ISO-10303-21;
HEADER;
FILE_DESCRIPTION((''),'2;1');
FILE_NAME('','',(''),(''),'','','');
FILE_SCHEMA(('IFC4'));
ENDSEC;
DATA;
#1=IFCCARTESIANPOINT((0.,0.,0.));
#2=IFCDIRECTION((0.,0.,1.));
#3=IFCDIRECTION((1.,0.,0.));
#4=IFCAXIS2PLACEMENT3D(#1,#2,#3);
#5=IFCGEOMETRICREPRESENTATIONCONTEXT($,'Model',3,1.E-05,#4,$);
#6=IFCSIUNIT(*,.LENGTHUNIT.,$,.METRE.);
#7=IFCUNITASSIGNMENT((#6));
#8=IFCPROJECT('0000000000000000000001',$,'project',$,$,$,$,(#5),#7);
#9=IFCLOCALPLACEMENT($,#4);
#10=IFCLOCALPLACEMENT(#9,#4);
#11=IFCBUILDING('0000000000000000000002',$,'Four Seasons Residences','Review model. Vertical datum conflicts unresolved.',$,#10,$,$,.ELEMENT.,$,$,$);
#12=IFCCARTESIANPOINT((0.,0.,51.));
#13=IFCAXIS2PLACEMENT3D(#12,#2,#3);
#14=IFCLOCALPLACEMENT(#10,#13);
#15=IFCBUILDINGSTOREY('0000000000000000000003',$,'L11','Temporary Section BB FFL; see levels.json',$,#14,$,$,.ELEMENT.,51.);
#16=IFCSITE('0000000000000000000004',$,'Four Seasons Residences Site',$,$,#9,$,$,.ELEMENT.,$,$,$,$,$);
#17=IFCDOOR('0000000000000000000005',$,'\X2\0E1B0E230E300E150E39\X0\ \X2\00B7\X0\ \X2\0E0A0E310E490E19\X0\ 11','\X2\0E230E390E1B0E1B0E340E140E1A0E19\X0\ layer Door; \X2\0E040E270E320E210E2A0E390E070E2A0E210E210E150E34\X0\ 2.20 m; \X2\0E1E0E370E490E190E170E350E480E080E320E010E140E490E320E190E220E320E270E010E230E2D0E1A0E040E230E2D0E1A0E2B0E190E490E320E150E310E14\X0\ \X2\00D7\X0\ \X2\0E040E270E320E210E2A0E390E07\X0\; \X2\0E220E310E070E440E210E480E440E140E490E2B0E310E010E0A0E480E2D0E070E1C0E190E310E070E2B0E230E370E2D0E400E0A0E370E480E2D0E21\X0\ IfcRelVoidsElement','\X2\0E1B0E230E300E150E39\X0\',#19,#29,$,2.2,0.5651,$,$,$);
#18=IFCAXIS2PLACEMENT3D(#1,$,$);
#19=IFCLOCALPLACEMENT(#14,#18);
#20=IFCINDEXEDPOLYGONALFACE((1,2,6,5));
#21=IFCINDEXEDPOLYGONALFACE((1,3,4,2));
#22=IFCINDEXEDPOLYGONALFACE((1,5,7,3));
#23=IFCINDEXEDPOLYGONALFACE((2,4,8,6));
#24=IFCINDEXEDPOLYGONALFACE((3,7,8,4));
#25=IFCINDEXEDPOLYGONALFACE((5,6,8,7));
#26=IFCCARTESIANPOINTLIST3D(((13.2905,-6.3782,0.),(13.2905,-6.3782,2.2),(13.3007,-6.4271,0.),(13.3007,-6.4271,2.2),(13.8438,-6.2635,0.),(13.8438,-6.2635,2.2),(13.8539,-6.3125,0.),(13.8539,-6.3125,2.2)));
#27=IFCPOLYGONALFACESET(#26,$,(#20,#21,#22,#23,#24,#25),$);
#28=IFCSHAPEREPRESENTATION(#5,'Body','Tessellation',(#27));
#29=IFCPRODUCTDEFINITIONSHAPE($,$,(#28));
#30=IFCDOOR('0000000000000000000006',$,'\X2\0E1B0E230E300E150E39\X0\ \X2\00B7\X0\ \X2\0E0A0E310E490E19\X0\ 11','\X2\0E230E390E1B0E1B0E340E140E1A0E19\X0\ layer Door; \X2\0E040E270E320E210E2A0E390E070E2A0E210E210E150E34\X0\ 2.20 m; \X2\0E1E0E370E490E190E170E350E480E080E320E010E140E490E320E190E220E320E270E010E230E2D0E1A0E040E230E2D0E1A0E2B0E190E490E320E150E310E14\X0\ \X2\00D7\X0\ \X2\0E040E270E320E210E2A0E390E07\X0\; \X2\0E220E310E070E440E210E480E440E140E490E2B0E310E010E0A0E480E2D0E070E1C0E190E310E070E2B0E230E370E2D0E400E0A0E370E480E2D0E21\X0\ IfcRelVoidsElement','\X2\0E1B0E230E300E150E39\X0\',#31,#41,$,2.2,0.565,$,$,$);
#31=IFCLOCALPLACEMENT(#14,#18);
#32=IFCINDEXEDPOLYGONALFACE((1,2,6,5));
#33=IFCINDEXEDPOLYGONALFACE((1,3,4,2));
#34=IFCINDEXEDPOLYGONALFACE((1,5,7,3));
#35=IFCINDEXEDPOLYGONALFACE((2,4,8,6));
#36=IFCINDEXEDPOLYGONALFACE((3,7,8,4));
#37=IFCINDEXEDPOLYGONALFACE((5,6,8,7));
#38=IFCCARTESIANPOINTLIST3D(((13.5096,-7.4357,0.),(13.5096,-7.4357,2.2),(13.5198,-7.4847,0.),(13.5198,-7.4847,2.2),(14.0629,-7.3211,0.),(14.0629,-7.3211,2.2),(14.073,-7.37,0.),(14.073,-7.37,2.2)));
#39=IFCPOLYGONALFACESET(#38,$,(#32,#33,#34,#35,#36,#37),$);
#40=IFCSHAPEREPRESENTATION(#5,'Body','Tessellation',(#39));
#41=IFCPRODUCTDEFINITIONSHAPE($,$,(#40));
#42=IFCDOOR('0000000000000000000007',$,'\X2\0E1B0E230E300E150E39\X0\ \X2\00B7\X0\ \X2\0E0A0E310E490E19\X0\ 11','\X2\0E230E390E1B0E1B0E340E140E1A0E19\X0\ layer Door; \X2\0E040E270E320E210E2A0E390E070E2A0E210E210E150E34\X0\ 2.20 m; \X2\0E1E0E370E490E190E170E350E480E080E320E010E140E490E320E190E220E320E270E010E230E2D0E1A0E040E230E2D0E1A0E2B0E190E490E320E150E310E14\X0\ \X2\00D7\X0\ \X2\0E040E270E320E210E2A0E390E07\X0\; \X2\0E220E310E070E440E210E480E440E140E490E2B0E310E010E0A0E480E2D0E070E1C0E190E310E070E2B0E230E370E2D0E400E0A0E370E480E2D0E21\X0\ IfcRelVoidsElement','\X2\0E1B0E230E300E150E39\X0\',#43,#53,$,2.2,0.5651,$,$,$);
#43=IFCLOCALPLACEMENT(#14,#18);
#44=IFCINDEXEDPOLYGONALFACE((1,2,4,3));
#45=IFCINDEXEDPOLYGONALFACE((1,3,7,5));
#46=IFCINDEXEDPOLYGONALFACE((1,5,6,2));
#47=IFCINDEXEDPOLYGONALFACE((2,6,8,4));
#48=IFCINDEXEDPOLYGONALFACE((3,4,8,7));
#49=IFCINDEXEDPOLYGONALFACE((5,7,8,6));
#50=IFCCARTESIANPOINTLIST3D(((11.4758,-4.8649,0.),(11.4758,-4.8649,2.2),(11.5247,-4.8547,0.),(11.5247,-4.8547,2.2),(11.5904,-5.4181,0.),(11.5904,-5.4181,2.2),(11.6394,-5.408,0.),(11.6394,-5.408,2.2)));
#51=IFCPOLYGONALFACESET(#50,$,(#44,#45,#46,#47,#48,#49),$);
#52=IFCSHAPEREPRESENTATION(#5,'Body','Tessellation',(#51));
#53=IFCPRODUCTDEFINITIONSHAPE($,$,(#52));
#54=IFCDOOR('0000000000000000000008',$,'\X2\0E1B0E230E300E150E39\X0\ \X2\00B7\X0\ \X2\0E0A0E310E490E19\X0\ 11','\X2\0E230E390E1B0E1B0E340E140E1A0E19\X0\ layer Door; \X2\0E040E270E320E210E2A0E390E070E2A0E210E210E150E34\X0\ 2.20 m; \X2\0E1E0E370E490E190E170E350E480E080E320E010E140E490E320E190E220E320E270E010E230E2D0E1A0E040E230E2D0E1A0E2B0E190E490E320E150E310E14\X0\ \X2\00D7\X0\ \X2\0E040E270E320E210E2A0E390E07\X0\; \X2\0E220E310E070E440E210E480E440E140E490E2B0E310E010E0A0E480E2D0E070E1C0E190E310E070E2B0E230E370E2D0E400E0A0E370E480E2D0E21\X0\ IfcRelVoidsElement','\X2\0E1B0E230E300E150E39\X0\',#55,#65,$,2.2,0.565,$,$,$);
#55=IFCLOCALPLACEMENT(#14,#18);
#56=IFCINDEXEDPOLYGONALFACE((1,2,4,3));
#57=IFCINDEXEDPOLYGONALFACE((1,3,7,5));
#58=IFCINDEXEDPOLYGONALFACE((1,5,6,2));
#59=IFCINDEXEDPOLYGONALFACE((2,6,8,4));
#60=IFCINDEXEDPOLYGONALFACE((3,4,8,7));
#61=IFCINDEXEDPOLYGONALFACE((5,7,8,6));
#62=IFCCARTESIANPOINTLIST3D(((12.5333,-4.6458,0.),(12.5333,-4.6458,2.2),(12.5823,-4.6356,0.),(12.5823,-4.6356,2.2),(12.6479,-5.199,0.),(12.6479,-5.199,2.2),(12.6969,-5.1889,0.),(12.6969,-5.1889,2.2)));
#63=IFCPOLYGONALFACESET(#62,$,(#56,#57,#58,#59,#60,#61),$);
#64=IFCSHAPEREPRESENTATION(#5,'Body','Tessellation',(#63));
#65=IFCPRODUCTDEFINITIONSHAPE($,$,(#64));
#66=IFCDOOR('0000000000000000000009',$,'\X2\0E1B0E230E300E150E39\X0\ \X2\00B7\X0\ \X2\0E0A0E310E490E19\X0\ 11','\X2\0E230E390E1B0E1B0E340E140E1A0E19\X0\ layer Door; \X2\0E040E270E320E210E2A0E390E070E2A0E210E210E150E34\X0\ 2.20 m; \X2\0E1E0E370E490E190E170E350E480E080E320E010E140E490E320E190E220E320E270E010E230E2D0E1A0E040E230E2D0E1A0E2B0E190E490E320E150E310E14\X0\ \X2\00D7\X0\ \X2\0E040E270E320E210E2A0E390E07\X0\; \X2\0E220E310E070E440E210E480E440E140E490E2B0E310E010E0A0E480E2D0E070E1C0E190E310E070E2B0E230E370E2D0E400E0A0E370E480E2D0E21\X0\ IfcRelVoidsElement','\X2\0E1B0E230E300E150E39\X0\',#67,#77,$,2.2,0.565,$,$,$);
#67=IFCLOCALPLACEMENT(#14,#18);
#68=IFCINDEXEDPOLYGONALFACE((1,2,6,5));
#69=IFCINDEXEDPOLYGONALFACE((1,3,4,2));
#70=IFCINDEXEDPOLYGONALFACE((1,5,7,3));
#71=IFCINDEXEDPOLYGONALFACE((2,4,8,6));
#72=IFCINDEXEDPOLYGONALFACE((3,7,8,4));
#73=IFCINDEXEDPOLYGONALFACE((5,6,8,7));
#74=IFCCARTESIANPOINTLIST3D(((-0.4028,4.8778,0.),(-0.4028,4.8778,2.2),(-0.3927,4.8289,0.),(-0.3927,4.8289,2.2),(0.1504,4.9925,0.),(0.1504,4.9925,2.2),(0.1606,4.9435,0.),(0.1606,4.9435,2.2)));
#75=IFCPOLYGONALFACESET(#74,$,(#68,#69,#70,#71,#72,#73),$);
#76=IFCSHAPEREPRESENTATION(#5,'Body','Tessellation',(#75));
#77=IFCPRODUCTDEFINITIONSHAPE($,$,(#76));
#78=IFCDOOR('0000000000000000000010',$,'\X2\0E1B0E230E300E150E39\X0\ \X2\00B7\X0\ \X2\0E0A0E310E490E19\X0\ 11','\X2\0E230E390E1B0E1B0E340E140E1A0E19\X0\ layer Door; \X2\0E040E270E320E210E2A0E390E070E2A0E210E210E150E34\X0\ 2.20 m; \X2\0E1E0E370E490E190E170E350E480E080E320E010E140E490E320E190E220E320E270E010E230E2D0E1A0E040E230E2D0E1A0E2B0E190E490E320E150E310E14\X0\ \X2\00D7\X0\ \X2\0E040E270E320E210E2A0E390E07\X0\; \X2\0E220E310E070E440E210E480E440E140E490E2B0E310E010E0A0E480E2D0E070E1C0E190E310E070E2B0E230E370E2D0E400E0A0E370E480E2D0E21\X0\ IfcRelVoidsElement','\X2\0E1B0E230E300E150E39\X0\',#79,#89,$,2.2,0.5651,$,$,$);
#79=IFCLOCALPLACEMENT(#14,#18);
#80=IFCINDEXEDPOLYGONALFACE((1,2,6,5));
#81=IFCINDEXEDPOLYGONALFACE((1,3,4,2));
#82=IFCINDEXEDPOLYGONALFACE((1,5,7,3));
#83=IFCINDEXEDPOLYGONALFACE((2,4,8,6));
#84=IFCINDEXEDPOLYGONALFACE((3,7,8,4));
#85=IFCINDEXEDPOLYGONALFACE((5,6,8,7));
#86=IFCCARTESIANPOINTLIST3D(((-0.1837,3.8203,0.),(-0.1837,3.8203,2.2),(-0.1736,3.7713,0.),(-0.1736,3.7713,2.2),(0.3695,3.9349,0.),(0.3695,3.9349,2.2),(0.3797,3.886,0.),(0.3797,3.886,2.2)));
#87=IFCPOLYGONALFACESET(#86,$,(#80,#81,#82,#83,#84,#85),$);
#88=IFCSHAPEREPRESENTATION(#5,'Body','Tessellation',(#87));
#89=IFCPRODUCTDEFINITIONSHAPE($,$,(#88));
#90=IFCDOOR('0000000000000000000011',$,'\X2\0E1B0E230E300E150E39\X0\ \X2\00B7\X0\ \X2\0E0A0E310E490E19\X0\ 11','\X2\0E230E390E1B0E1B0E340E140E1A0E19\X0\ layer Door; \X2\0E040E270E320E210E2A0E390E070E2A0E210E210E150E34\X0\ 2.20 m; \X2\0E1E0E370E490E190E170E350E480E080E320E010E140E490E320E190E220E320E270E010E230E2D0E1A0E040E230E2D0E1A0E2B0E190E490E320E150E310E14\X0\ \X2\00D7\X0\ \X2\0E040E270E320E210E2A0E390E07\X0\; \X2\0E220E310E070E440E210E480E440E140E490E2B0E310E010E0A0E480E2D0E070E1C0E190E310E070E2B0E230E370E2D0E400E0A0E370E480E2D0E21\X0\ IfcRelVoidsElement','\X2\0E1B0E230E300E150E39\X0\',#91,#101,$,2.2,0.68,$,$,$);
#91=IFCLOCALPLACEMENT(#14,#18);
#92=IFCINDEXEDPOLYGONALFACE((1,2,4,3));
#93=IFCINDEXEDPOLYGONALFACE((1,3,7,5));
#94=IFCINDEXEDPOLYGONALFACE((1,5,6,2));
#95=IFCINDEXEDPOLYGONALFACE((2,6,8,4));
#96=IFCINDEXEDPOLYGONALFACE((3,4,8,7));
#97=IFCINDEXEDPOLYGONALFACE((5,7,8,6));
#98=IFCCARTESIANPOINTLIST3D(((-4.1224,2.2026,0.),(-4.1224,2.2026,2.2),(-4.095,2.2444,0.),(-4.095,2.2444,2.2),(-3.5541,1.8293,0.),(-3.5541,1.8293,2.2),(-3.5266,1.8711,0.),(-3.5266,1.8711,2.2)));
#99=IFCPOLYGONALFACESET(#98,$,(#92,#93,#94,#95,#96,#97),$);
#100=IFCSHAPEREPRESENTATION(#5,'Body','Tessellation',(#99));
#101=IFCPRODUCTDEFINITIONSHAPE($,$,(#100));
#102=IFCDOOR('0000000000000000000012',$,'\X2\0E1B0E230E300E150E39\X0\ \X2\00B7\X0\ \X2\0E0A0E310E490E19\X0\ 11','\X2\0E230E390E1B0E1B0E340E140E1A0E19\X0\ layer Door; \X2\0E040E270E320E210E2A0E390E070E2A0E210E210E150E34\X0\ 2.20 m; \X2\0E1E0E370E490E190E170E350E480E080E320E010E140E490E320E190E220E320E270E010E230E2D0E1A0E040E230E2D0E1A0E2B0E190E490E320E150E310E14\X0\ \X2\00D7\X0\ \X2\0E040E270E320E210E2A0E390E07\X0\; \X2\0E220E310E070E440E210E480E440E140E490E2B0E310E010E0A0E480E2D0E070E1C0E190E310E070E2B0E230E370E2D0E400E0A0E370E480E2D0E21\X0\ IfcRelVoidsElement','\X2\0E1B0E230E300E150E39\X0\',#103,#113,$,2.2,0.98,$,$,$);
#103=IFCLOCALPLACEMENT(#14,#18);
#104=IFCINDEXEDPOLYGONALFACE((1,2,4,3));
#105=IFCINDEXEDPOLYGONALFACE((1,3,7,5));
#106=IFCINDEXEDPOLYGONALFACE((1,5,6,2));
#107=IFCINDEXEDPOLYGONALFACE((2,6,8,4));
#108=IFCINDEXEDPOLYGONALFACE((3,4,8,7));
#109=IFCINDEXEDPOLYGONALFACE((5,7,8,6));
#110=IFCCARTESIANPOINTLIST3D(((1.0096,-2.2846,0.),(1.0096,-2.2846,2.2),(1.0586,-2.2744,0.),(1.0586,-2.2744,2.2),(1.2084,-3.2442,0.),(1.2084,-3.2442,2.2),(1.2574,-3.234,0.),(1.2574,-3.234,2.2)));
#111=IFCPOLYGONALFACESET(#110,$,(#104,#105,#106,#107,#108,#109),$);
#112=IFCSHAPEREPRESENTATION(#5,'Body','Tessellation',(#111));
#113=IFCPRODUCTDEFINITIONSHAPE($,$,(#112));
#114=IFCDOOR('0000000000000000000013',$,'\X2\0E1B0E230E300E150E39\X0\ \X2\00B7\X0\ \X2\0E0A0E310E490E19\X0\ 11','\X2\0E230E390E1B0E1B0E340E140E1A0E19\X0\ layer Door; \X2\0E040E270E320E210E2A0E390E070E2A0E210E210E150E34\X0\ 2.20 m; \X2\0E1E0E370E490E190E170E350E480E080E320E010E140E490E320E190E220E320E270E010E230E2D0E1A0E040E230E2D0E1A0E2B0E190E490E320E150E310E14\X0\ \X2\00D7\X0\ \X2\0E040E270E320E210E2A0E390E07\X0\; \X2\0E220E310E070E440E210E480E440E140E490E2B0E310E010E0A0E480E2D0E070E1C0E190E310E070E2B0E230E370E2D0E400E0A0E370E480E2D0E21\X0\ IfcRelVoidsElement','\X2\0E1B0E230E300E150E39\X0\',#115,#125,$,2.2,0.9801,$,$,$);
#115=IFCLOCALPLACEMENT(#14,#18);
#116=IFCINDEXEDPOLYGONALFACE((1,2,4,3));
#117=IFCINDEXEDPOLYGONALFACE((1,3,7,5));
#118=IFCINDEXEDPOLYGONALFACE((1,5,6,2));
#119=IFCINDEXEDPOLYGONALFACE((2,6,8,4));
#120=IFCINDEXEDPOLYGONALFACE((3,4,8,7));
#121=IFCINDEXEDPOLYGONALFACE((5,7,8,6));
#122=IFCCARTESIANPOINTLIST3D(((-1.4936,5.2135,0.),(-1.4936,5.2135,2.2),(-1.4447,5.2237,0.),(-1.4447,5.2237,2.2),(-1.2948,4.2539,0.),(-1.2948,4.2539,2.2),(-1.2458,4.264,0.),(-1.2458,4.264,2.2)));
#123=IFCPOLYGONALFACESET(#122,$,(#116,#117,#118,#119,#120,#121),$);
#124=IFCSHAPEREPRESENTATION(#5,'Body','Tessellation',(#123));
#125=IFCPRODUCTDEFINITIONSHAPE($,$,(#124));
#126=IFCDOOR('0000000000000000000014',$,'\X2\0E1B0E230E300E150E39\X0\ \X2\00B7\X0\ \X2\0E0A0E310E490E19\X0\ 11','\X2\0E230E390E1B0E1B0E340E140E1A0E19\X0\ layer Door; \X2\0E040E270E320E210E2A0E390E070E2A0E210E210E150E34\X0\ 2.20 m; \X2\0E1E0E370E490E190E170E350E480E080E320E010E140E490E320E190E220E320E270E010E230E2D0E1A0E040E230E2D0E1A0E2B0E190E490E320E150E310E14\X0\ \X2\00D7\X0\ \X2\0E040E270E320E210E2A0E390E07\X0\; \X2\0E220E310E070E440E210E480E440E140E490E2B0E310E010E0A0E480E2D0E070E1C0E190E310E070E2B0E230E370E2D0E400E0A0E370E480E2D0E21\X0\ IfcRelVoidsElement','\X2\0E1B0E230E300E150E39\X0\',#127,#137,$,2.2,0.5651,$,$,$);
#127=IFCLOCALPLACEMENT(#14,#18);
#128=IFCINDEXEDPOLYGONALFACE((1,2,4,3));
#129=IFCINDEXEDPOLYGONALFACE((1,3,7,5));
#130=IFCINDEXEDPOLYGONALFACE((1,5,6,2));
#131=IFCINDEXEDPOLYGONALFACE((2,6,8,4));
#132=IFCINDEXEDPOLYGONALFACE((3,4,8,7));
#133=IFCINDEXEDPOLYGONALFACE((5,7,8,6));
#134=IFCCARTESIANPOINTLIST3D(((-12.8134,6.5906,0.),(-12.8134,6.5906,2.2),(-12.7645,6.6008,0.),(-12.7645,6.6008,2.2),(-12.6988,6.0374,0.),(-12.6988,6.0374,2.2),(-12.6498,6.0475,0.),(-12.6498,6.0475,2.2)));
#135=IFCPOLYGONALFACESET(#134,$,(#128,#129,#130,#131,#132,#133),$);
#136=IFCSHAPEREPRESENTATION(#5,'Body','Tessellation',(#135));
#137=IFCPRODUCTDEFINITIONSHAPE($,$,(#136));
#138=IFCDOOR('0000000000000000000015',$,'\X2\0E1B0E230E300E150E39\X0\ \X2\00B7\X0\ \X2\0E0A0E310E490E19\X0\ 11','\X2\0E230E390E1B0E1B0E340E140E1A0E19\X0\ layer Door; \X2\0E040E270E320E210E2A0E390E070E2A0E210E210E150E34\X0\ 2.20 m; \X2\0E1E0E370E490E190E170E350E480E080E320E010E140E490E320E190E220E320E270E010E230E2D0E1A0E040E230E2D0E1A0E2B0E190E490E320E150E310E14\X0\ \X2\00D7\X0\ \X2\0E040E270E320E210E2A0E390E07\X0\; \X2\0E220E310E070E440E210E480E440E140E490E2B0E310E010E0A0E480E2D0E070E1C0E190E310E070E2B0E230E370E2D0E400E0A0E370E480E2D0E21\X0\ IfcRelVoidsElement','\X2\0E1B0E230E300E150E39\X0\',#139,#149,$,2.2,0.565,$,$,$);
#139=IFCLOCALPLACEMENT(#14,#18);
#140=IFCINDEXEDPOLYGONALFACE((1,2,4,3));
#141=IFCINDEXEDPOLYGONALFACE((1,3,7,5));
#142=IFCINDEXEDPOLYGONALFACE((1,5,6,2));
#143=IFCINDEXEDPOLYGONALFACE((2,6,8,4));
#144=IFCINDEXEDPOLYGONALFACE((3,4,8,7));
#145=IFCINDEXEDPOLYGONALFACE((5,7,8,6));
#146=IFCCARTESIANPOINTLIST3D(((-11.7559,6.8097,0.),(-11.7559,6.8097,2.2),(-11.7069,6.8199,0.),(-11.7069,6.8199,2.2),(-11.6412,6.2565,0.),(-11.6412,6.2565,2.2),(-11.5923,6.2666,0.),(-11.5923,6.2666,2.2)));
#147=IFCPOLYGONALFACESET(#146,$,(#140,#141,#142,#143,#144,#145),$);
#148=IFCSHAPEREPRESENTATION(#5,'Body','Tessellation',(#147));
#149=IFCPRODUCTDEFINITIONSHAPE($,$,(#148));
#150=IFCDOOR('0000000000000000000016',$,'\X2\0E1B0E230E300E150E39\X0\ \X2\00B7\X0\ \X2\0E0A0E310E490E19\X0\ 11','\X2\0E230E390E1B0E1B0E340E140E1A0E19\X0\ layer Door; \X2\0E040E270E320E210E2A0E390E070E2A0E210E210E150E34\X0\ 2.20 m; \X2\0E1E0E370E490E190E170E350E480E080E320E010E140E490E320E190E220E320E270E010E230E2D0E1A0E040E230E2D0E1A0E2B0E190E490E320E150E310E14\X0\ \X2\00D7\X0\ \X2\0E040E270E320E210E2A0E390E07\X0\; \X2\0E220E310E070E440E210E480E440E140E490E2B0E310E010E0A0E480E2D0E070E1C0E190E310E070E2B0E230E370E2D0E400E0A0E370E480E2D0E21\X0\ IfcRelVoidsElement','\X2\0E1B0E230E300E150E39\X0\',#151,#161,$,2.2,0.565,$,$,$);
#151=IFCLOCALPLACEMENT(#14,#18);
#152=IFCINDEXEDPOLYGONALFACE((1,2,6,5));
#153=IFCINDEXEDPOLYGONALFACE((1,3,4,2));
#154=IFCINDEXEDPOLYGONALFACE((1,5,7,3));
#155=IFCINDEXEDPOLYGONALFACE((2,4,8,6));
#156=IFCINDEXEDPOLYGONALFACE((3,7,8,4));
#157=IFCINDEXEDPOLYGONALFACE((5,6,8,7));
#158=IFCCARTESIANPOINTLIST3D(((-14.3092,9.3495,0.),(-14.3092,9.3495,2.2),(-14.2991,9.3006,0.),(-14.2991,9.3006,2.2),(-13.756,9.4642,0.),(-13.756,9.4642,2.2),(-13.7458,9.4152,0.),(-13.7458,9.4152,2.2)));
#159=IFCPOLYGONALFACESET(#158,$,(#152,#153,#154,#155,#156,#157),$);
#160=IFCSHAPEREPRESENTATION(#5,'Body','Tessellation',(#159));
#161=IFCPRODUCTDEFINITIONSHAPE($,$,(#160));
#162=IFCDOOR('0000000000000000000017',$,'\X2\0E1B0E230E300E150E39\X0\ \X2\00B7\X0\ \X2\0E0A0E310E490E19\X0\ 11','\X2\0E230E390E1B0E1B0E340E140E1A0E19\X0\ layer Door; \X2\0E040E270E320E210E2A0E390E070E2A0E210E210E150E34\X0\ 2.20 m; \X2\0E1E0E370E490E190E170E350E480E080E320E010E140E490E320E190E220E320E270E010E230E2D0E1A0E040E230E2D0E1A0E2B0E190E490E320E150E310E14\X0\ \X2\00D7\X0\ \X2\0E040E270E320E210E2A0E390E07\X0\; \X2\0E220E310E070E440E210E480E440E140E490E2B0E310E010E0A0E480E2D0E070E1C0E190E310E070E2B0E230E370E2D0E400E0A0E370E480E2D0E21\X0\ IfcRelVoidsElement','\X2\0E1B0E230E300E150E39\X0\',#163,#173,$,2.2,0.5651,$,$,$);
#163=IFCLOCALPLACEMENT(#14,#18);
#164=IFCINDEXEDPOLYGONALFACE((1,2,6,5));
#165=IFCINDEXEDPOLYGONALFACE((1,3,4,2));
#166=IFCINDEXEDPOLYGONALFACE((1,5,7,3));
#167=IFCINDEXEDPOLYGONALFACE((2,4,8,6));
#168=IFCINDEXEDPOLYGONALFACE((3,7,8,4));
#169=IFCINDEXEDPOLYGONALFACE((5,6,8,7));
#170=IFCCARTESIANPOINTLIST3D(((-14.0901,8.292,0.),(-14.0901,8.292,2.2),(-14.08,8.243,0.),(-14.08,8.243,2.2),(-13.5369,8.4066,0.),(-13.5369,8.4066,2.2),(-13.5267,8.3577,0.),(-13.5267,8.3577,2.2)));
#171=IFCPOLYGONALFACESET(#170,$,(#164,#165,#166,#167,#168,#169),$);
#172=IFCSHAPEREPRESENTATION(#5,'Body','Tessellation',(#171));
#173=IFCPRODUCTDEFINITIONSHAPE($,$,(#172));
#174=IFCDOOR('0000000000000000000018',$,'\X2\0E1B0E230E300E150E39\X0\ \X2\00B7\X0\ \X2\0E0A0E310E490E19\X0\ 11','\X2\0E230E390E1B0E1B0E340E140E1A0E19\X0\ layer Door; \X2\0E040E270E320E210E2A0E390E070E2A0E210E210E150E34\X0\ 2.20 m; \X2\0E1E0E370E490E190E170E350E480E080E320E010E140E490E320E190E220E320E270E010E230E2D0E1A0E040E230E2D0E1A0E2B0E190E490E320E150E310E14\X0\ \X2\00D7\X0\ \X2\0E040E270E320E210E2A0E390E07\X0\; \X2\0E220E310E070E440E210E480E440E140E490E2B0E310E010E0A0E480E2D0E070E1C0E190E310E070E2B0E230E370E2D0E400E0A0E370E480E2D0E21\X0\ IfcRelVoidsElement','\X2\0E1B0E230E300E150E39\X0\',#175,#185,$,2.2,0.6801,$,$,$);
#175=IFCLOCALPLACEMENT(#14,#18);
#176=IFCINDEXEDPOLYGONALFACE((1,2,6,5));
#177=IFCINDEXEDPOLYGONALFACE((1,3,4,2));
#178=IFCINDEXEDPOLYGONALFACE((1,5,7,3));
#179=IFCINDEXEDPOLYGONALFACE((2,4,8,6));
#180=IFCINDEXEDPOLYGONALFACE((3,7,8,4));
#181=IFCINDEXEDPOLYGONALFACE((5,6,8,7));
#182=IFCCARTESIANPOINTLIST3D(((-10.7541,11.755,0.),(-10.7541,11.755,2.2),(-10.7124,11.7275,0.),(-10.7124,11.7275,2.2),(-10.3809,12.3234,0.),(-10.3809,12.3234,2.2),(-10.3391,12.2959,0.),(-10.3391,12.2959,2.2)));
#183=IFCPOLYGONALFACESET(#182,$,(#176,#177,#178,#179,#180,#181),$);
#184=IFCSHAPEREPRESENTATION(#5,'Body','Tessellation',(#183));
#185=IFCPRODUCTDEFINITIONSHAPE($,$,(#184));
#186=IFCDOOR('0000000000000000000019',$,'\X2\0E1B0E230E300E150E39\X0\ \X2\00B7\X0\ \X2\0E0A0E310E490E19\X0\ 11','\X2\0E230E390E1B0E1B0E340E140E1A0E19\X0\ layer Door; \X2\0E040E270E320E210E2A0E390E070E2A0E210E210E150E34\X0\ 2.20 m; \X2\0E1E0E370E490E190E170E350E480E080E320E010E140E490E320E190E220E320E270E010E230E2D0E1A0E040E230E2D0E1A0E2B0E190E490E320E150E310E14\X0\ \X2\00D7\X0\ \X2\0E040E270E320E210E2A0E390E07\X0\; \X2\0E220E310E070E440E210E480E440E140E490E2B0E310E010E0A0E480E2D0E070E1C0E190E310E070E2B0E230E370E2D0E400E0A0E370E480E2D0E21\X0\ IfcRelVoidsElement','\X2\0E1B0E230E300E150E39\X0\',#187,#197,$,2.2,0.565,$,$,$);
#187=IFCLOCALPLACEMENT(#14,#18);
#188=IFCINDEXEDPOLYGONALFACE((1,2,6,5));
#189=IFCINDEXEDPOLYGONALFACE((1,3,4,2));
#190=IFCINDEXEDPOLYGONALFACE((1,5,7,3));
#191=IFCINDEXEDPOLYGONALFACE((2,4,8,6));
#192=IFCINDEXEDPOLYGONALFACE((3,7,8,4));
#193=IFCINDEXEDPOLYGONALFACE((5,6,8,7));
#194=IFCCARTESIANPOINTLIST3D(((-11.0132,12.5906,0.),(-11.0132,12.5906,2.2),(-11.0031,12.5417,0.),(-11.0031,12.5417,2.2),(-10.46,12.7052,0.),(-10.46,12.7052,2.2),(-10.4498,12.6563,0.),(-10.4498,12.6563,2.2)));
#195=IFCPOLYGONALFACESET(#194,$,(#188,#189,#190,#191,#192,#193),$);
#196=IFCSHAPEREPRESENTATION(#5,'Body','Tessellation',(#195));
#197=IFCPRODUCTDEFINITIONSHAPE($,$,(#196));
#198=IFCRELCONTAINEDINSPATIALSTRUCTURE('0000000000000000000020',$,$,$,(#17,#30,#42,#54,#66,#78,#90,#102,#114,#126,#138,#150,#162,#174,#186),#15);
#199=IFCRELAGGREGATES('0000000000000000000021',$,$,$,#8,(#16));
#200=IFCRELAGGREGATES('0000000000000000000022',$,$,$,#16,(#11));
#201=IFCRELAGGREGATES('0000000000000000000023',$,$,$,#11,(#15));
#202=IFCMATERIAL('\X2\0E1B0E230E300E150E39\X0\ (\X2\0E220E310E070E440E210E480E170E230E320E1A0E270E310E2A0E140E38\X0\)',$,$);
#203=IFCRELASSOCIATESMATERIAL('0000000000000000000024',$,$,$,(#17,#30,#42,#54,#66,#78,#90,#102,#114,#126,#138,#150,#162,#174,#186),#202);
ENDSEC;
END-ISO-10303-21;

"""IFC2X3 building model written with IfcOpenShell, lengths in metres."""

from ifc_helpers import new_model, si_unit, frame, origin_with_axes, place, context, project, spatial, polyline, outline, extrude, material, element, save


model = new_model("IFC2X3")

# Units and contexts
model_context = context("Model", 3, precision=1e-05, world=origin_with_axes())
ifc_project = project(units=[si_unit("LENGTHUNIT", "METRE")], contexts=[model_context])

# Site, building, storey
site_placement = place(None, origin_with_axes())
site = spatial("IfcSite", under=ifc_project, at=site_placement, Name="Four Seasons Residences Site", CompositionType="ELEMENT")
building_placement = place(site_placement, origin_with_axes())
building = spatial("IfcBuilding", under=site, at=building_placement, Name="Four Seasons Residences", Description="Review model. Vertical datum conflicts unresolved.", CompositionType="ELEMENT")
storey_placement = place(building_placement, frame((0.0, 0.0, 51.0), z_axis=(0.0, 0.0, 1.0), x_axis=(1.0, 0.0, 0.0)))
storey = spatial("IfcBuildingStorey", under=building, at=storey_placement, Name="L11", Description="Temporary Section BB FFL; see levels.json", CompositionType="ELEMENT", Elevation=51.0)

# Doors
ifc_material_1 = material(Name="ประตู (ยังไม่ทราบวัสดุ)")
door_1_placement = place(storey_placement, origin_with_axes())
element("IfcDoor", 1, at=door_1_placement, inside=storey, material=ifc_material_1, Name="ประตู · ชั้น 11", Description="รูปปิดบน layer Door; ความสูงสมมติ 2.20 m; พื้นที่จากด้านยาวกรอบครอบหน้าตัด × ความสูง; ยังไม่ได้หักช่องผนังหรือเชื่อม IfcRelVoidsElement", ObjectType="ประตู", OverallHeight=2.2, OverallWidth=0.5651, context=model_context, shape_type="SweptSolid", body=[
    extrude(outline(polyline([(13.2905, -6.3782), (13.8438, -6.2635), (13.8539, -6.3125), (13.3007, -6.4271), (13.2905, -6.3782)])), origin_with_axes(), (0.0, 0.0, 1.0), 2.2),
])
door_2_placement = place(storey_placement, origin_with_axes())
element("IfcDoor", 2, at=door_2_placement, inside=storey, material=ifc_material_1, Name="ประตู · ชั้น 11", Description="รูปปิดบน layer Door; ความสูงสมมติ 2.20 m; พื้นที่จากด้านยาวกรอบครอบหน้าตัด × ความสูง; ยังไม่ได้หักช่องผนังหรือเชื่อม IfcRelVoidsElement", ObjectType="ประตู", OverallHeight=2.2, OverallWidth=0.565, context=model_context, shape_type="SweptSolid", body=[
    extrude(outline(polyline([(13.5198, -7.4847), (14.073, -7.37), (14.0629, -7.3211), (13.5096, -7.4357), (13.5198, -7.4847)])), origin_with_axes(), (0.0, 0.0, 1.0), 2.2),
])
door_3_placement = place(storey_placement, origin_with_axes())
element("IfcDoor", 3, at=door_3_placement, inside=storey, material=ifc_material_1, Name="ประตู · ชั้น 11", Description="รูปปิดบน layer Door; ความสูงสมมติ 2.20 m; พื้นที่จากด้านยาวกรอบครอบหน้าตัด × ความสูง; ยังไม่ได้หักช่องผนังหรือเชื่อม IfcRelVoidsElement", ObjectType="ประตู", OverallHeight=2.2, OverallWidth=0.5651, context=model_context, shape_type="SweptSolid", body=[
    extrude(outline(polyline([(11.4758, -4.8649), (11.5904, -5.4181), (11.6394, -5.408), (11.5247, -4.8547), (11.4758, -4.8649)])), origin_with_axes(), (0.0, 0.0, 1.0), 2.2),
])
door_4_placement = place(storey_placement, origin_with_axes())
element("IfcDoor", 4, at=door_4_placement, inside=storey, material=ifc_material_1, Name="ประตู · ชั้น 11", Description="รูปปิดบน layer Door; ความสูงสมมติ 2.20 m; พื้นที่จากด้านยาวกรอบครอบหน้าตัด × ความสูง; ยังไม่ได้หักช่องผนังหรือเชื่อม IfcRelVoidsElement", ObjectType="ประตู", OverallHeight=2.2, OverallWidth=0.565, context=model_context, shape_type="SweptSolid", body=[
    extrude(outline(polyline([(12.5823, -4.6356), (12.6969, -5.1889), (12.6479, -5.199), (12.5333, -4.6458), (12.5823, -4.6356)])), origin_with_axes(), (0.0, 0.0, 1.0), 2.2),
])
door_5_placement = place(storey_placement, origin_with_axes())
element("IfcDoor", 5, at=door_5_placement, inside=storey, material=ifc_material_1, Name="ประตู · ชั้น 11", Description="รูปปิดบน layer Door; ความสูงสมมติ 2.20 m; พื้นที่จากด้านยาวกรอบครอบหน้าตัด × ความสูง; ยังไม่ได้หักช่องผนังหรือเชื่อม IfcRelVoidsElement", ObjectType="ประตู", OverallHeight=2.2, OverallWidth=0.565, context=model_context, shape_type="SweptSolid", body=[
    extrude(outline(polyline([(-0.4028, 4.8778), (0.1504, 4.9925), (0.1606, 4.9435), (-0.3927, 4.8289), (-0.4028, 4.8778)])), origin_with_axes(), (0.0, 0.0, 1.0), 2.2),
])
door_6_placement = place(storey_placement, origin_with_axes())
element("IfcDoor", 6, at=door_6_placement, inside=storey, material=ifc_material_1, Name="ประตู · ชั้น 11", Description="รูปปิดบน layer Door; ความสูงสมมติ 2.20 m; พื้นที่จากด้านยาวกรอบครอบหน้าตัด × ความสูง; ยังไม่ได้หักช่องผนังหรือเชื่อม IfcRelVoidsElement", ObjectType="ประตู", OverallHeight=2.2, OverallWidth=0.5651, context=model_context, shape_type="SweptSolid", body=[
    extrude(outline(polyline([(-0.1736, 3.7713), (0.3797, 3.886), (0.3695, 3.9349), (-0.1837, 3.8203), (-0.1736, 3.7713)])), origin_with_axes(), (0.0, 0.0, 1.0), 2.2),
])
door_7_placement = place(storey_placement, origin_with_axes())
element("IfcDoor", 7, at=door_7_placement, inside=storey, material=ifc_material_1, Name="ประตู · ชั้น 11", Description="รูปปิดบน layer Door; ความสูงสมมติ 2.20 m; พื้นที่จากด้านยาวกรอบครอบหน้าตัด × ความสูง; ยังไม่ได้หักช่องผนังหรือเชื่อม IfcRelVoidsElement", ObjectType="ประตู", OverallHeight=2.2, OverallWidth=0.68, context=model_context, shape_type="SweptSolid", body=[
    extrude(outline(polyline([(-3.5541, 1.8293), (-4.1224, 2.2026), (-4.095, 2.2444), (-3.5266, 1.8711), (-3.5541, 1.8293)])), origin_with_axes(), (0.0, 0.0, 1.0), 2.2),
])
door_8_placement = place(storey_placement, origin_with_axes())
element("IfcDoor", 8, at=door_8_placement, inside=storey, material=ifc_material_1, Name="ประตู · ชั้น 11", Description="รูปปิดบน layer Door; ความสูงสมมติ 2.20 m; พื้นที่จากด้านยาวกรอบครอบหน้าตัด × ความสูง; ยังไม่ได้หักช่องผนังหรือเชื่อม IfcRelVoidsElement", ObjectType="ประตู", OverallHeight=2.2, OverallWidth=0.98, context=model_context, shape_type="SweptSolid", body=[
    extrude(outline(polyline([(1.2574, -3.234), (1.2084, -3.2442), (1.0096, -2.2846), (1.0586, -2.2744), (1.2574, -3.234)])), origin_with_axes(), (0.0, 0.0, 1.0), 2.2),
])
door_9_placement = place(storey_placement, origin_with_axes())
element("IfcDoor", 9, at=door_9_placement, inside=storey, material=ifc_material_1, Name="ประตู · ชั้น 11", Description="รูปปิดบน layer Door; ความสูงสมมติ 2.20 m; พื้นที่จากด้านยาวกรอบครอบหน้าตัด × ความสูง; ยังไม่ได้หักช่องผนังหรือเชื่อม IfcRelVoidsElement", ObjectType="ประตู", OverallHeight=2.2, OverallWidth=0.9801, context=model_context, shape_type="SweptSolid", body=[
    extrude(outline(polyline([(-1.4936, 5.2135), (-1.4447, 5.2237), (-1.2458, 4.264), (-1.2948, 4.2539), (-1.4936, 5.2135)])), origin_with_axes(), (0.0, 0.0, 1.0), 2.2),
])
door_10_placement = place(storey_placement, origin_with_axes())
element("IfcDoor", 10, at=door_10_placement, inside=storey, material=ifc_material_1, Name="ประตู · ชั้น 11", Description="รูปปิดบน layer Door; ความสูงสมมติ 2.20 m; พื้นที่จากด้านยาวกรอบครอบหน้าตัด × ความสูง; ยังไม่ได้หักช่องผนังหรือเชื่อม IfcRelVoidsElement", ObjectType="ประตู", OverallHeight=2.2, OverallWidth=0.5651, context=model_context, shape_type="SweptSolid", body=[
    extrude(outline(polyline([(-12.6988, 6.0374), (-12.8134, 6.5906), (-12.7645, 6.6008), (-12.6498, 6.0475), (-12.6988, 6.0374)])), origin_with_axes(), (0.0, 0.0, 1.0), 2.2),
])
door_11_placement = place(storey_placement, origin_with_axes())
element("IfcDoor", 11, at=door_11_placement, inside=storey, material=ifc_material_1, Name="ประตู · ชั้น 11", Description="รูปปิดบน layer Door; ความสูงสมมติ 2.20 m; พื้นที่จากด้านยาวกรอบครอบหน้าตัด × ความสูง; ยังไม่ได้หักช่องผนังหรือเชื่อม IfcRelVoidsElement", ObjectType="ประตู", OverallHeight=2.2, OverallWidth=0.565, context=model_context, shape_type="SweptSolid", body=[
    extrude(outline(polyline([(-11.5923, 6.2666), (-11.7069, 6.8199), (-11.7559, 6.8097), (-11.6412, 6.2565), (-11.5923, 6.2666)])), origin_with_axes(), (0.0, 0.0, 1.0), 2.2),
])
door_12_placement = place(storey_placement, origin_with_axes())
element("IfcDoor", 12, at=door_12_placement, inside=storey, material=ifc_material_1, Name="ประตู · ชั้น 11", Description="รูปปิดบน layer Door; ความสูงสมมติ 2.20 m; พื้นที่จากด้านยาวกรอบครอบหน้าตัด × ความสูง; ยังไม่ได้หักช่องผนังหรือเชื่อม IfcRelVoidsElement", ObjectType="ประตู", OverallHeight=2.2, OverallWidth=0.565, context=model_context, shape_type="SweptSolid", body=[
    extrude(outline(polyline([(-13.756, 9.4642), (-14.3092, 9.3495), (-14.2991, 9.3006), (-13.7458, 9.4152), (-13.756, 9.4642)])), origin_with_axes(), (0.0, 0.0, 1.0), 2.2),
])
door_13_placement = place(storey_placement, origin_with_axes())
element("IfcDoor", 13, at=door_13_placement, inside=storey, material=ifc_material_1, Name="ประตู · ชั้น 11", Description="รูปปิดบน layer Door; ความสูงสมมติ 2.20 m; พื้นที่จากด้านยาวกรอบครอบหน้าตัด × ความสูง; ยังไม่ได้หักช่องผนังหรือเชื่อม IfcRelVoidsElement", ObjectType="ประตู", OverallHeight=2.2, OverallWidth=0.5651, context=model_context, shape_type="SweptSolid", body=[
    extrude(outline(polyline([(-13.5267, 8.3577), (-14.08, 8.243), (-14.0901, 8.292), (-13.5369, 8.4066), (-13.5267, 8.3577)])), origin_with_axes(), (0.0, 0.0, 1.0), 2.2),
])
door_14_placement = place(storey_placement, origin_with_axes())
element("IfcDoor", 14, at=door_14_placement, inside=storey, material=ifc_material_1, Name="ประตู · ชั้น 11", Description="รูปปิดบน layer Door; ความสูงสมมติ 2.20 m; พื้นที่จากด้านยาวกรอบครอบหน้าตัด × ความสูง; ยังไม่ได้หักช่องผนังหรือเชื่อม IfcRelVoidsElement", ObjectType="ประตู", OverallHeight=2.2, OverallWidth=0.6801, context=model_context, shape_type="SweptSolid", body=[
    extrude(outline(polyline([(-10.7541, 11.755), (-10.3809, 12.3234), (-10.3391, 12.2959), (-10.7124, 11.7275), (-10.7541, 11.755)])), origin_with_axes(), (0.0, 0.0, 1.0), 2.2),
])
door_15_placement = place(storey_placement, origin_with_axes())
element("IfcDoor", 15, at=door_15_placement, inside=storey, material=ifc_material_1, Name="ประตู · ชั้น 11", Description="รูปปิดบน layer Door; ความสูงสมมติ 2.20 m; พื้นที่จากด้านยาวกรอบครอบหน้าตัด × ความสูง; ยังไม่ได้หักช่องผนังหรือเชื่อม IfcRelVoidsElement", ObjectType="ประตู", OverallHeight=2.2, OverallWidth=0.565, context=model_context, shape_type="SweptSolid", body=[
    extrude(outline(polyline([(-11.0031, 12.5417), (-10.4498, 12.6563), (-10.46, 12.7052), (-11.0132, 12.5906), (-11.0031, 12.5417)])), origin_with_axes(), (0.0, 0.0, 1.0), 2.2),
])

save(model, "model.ifc")
